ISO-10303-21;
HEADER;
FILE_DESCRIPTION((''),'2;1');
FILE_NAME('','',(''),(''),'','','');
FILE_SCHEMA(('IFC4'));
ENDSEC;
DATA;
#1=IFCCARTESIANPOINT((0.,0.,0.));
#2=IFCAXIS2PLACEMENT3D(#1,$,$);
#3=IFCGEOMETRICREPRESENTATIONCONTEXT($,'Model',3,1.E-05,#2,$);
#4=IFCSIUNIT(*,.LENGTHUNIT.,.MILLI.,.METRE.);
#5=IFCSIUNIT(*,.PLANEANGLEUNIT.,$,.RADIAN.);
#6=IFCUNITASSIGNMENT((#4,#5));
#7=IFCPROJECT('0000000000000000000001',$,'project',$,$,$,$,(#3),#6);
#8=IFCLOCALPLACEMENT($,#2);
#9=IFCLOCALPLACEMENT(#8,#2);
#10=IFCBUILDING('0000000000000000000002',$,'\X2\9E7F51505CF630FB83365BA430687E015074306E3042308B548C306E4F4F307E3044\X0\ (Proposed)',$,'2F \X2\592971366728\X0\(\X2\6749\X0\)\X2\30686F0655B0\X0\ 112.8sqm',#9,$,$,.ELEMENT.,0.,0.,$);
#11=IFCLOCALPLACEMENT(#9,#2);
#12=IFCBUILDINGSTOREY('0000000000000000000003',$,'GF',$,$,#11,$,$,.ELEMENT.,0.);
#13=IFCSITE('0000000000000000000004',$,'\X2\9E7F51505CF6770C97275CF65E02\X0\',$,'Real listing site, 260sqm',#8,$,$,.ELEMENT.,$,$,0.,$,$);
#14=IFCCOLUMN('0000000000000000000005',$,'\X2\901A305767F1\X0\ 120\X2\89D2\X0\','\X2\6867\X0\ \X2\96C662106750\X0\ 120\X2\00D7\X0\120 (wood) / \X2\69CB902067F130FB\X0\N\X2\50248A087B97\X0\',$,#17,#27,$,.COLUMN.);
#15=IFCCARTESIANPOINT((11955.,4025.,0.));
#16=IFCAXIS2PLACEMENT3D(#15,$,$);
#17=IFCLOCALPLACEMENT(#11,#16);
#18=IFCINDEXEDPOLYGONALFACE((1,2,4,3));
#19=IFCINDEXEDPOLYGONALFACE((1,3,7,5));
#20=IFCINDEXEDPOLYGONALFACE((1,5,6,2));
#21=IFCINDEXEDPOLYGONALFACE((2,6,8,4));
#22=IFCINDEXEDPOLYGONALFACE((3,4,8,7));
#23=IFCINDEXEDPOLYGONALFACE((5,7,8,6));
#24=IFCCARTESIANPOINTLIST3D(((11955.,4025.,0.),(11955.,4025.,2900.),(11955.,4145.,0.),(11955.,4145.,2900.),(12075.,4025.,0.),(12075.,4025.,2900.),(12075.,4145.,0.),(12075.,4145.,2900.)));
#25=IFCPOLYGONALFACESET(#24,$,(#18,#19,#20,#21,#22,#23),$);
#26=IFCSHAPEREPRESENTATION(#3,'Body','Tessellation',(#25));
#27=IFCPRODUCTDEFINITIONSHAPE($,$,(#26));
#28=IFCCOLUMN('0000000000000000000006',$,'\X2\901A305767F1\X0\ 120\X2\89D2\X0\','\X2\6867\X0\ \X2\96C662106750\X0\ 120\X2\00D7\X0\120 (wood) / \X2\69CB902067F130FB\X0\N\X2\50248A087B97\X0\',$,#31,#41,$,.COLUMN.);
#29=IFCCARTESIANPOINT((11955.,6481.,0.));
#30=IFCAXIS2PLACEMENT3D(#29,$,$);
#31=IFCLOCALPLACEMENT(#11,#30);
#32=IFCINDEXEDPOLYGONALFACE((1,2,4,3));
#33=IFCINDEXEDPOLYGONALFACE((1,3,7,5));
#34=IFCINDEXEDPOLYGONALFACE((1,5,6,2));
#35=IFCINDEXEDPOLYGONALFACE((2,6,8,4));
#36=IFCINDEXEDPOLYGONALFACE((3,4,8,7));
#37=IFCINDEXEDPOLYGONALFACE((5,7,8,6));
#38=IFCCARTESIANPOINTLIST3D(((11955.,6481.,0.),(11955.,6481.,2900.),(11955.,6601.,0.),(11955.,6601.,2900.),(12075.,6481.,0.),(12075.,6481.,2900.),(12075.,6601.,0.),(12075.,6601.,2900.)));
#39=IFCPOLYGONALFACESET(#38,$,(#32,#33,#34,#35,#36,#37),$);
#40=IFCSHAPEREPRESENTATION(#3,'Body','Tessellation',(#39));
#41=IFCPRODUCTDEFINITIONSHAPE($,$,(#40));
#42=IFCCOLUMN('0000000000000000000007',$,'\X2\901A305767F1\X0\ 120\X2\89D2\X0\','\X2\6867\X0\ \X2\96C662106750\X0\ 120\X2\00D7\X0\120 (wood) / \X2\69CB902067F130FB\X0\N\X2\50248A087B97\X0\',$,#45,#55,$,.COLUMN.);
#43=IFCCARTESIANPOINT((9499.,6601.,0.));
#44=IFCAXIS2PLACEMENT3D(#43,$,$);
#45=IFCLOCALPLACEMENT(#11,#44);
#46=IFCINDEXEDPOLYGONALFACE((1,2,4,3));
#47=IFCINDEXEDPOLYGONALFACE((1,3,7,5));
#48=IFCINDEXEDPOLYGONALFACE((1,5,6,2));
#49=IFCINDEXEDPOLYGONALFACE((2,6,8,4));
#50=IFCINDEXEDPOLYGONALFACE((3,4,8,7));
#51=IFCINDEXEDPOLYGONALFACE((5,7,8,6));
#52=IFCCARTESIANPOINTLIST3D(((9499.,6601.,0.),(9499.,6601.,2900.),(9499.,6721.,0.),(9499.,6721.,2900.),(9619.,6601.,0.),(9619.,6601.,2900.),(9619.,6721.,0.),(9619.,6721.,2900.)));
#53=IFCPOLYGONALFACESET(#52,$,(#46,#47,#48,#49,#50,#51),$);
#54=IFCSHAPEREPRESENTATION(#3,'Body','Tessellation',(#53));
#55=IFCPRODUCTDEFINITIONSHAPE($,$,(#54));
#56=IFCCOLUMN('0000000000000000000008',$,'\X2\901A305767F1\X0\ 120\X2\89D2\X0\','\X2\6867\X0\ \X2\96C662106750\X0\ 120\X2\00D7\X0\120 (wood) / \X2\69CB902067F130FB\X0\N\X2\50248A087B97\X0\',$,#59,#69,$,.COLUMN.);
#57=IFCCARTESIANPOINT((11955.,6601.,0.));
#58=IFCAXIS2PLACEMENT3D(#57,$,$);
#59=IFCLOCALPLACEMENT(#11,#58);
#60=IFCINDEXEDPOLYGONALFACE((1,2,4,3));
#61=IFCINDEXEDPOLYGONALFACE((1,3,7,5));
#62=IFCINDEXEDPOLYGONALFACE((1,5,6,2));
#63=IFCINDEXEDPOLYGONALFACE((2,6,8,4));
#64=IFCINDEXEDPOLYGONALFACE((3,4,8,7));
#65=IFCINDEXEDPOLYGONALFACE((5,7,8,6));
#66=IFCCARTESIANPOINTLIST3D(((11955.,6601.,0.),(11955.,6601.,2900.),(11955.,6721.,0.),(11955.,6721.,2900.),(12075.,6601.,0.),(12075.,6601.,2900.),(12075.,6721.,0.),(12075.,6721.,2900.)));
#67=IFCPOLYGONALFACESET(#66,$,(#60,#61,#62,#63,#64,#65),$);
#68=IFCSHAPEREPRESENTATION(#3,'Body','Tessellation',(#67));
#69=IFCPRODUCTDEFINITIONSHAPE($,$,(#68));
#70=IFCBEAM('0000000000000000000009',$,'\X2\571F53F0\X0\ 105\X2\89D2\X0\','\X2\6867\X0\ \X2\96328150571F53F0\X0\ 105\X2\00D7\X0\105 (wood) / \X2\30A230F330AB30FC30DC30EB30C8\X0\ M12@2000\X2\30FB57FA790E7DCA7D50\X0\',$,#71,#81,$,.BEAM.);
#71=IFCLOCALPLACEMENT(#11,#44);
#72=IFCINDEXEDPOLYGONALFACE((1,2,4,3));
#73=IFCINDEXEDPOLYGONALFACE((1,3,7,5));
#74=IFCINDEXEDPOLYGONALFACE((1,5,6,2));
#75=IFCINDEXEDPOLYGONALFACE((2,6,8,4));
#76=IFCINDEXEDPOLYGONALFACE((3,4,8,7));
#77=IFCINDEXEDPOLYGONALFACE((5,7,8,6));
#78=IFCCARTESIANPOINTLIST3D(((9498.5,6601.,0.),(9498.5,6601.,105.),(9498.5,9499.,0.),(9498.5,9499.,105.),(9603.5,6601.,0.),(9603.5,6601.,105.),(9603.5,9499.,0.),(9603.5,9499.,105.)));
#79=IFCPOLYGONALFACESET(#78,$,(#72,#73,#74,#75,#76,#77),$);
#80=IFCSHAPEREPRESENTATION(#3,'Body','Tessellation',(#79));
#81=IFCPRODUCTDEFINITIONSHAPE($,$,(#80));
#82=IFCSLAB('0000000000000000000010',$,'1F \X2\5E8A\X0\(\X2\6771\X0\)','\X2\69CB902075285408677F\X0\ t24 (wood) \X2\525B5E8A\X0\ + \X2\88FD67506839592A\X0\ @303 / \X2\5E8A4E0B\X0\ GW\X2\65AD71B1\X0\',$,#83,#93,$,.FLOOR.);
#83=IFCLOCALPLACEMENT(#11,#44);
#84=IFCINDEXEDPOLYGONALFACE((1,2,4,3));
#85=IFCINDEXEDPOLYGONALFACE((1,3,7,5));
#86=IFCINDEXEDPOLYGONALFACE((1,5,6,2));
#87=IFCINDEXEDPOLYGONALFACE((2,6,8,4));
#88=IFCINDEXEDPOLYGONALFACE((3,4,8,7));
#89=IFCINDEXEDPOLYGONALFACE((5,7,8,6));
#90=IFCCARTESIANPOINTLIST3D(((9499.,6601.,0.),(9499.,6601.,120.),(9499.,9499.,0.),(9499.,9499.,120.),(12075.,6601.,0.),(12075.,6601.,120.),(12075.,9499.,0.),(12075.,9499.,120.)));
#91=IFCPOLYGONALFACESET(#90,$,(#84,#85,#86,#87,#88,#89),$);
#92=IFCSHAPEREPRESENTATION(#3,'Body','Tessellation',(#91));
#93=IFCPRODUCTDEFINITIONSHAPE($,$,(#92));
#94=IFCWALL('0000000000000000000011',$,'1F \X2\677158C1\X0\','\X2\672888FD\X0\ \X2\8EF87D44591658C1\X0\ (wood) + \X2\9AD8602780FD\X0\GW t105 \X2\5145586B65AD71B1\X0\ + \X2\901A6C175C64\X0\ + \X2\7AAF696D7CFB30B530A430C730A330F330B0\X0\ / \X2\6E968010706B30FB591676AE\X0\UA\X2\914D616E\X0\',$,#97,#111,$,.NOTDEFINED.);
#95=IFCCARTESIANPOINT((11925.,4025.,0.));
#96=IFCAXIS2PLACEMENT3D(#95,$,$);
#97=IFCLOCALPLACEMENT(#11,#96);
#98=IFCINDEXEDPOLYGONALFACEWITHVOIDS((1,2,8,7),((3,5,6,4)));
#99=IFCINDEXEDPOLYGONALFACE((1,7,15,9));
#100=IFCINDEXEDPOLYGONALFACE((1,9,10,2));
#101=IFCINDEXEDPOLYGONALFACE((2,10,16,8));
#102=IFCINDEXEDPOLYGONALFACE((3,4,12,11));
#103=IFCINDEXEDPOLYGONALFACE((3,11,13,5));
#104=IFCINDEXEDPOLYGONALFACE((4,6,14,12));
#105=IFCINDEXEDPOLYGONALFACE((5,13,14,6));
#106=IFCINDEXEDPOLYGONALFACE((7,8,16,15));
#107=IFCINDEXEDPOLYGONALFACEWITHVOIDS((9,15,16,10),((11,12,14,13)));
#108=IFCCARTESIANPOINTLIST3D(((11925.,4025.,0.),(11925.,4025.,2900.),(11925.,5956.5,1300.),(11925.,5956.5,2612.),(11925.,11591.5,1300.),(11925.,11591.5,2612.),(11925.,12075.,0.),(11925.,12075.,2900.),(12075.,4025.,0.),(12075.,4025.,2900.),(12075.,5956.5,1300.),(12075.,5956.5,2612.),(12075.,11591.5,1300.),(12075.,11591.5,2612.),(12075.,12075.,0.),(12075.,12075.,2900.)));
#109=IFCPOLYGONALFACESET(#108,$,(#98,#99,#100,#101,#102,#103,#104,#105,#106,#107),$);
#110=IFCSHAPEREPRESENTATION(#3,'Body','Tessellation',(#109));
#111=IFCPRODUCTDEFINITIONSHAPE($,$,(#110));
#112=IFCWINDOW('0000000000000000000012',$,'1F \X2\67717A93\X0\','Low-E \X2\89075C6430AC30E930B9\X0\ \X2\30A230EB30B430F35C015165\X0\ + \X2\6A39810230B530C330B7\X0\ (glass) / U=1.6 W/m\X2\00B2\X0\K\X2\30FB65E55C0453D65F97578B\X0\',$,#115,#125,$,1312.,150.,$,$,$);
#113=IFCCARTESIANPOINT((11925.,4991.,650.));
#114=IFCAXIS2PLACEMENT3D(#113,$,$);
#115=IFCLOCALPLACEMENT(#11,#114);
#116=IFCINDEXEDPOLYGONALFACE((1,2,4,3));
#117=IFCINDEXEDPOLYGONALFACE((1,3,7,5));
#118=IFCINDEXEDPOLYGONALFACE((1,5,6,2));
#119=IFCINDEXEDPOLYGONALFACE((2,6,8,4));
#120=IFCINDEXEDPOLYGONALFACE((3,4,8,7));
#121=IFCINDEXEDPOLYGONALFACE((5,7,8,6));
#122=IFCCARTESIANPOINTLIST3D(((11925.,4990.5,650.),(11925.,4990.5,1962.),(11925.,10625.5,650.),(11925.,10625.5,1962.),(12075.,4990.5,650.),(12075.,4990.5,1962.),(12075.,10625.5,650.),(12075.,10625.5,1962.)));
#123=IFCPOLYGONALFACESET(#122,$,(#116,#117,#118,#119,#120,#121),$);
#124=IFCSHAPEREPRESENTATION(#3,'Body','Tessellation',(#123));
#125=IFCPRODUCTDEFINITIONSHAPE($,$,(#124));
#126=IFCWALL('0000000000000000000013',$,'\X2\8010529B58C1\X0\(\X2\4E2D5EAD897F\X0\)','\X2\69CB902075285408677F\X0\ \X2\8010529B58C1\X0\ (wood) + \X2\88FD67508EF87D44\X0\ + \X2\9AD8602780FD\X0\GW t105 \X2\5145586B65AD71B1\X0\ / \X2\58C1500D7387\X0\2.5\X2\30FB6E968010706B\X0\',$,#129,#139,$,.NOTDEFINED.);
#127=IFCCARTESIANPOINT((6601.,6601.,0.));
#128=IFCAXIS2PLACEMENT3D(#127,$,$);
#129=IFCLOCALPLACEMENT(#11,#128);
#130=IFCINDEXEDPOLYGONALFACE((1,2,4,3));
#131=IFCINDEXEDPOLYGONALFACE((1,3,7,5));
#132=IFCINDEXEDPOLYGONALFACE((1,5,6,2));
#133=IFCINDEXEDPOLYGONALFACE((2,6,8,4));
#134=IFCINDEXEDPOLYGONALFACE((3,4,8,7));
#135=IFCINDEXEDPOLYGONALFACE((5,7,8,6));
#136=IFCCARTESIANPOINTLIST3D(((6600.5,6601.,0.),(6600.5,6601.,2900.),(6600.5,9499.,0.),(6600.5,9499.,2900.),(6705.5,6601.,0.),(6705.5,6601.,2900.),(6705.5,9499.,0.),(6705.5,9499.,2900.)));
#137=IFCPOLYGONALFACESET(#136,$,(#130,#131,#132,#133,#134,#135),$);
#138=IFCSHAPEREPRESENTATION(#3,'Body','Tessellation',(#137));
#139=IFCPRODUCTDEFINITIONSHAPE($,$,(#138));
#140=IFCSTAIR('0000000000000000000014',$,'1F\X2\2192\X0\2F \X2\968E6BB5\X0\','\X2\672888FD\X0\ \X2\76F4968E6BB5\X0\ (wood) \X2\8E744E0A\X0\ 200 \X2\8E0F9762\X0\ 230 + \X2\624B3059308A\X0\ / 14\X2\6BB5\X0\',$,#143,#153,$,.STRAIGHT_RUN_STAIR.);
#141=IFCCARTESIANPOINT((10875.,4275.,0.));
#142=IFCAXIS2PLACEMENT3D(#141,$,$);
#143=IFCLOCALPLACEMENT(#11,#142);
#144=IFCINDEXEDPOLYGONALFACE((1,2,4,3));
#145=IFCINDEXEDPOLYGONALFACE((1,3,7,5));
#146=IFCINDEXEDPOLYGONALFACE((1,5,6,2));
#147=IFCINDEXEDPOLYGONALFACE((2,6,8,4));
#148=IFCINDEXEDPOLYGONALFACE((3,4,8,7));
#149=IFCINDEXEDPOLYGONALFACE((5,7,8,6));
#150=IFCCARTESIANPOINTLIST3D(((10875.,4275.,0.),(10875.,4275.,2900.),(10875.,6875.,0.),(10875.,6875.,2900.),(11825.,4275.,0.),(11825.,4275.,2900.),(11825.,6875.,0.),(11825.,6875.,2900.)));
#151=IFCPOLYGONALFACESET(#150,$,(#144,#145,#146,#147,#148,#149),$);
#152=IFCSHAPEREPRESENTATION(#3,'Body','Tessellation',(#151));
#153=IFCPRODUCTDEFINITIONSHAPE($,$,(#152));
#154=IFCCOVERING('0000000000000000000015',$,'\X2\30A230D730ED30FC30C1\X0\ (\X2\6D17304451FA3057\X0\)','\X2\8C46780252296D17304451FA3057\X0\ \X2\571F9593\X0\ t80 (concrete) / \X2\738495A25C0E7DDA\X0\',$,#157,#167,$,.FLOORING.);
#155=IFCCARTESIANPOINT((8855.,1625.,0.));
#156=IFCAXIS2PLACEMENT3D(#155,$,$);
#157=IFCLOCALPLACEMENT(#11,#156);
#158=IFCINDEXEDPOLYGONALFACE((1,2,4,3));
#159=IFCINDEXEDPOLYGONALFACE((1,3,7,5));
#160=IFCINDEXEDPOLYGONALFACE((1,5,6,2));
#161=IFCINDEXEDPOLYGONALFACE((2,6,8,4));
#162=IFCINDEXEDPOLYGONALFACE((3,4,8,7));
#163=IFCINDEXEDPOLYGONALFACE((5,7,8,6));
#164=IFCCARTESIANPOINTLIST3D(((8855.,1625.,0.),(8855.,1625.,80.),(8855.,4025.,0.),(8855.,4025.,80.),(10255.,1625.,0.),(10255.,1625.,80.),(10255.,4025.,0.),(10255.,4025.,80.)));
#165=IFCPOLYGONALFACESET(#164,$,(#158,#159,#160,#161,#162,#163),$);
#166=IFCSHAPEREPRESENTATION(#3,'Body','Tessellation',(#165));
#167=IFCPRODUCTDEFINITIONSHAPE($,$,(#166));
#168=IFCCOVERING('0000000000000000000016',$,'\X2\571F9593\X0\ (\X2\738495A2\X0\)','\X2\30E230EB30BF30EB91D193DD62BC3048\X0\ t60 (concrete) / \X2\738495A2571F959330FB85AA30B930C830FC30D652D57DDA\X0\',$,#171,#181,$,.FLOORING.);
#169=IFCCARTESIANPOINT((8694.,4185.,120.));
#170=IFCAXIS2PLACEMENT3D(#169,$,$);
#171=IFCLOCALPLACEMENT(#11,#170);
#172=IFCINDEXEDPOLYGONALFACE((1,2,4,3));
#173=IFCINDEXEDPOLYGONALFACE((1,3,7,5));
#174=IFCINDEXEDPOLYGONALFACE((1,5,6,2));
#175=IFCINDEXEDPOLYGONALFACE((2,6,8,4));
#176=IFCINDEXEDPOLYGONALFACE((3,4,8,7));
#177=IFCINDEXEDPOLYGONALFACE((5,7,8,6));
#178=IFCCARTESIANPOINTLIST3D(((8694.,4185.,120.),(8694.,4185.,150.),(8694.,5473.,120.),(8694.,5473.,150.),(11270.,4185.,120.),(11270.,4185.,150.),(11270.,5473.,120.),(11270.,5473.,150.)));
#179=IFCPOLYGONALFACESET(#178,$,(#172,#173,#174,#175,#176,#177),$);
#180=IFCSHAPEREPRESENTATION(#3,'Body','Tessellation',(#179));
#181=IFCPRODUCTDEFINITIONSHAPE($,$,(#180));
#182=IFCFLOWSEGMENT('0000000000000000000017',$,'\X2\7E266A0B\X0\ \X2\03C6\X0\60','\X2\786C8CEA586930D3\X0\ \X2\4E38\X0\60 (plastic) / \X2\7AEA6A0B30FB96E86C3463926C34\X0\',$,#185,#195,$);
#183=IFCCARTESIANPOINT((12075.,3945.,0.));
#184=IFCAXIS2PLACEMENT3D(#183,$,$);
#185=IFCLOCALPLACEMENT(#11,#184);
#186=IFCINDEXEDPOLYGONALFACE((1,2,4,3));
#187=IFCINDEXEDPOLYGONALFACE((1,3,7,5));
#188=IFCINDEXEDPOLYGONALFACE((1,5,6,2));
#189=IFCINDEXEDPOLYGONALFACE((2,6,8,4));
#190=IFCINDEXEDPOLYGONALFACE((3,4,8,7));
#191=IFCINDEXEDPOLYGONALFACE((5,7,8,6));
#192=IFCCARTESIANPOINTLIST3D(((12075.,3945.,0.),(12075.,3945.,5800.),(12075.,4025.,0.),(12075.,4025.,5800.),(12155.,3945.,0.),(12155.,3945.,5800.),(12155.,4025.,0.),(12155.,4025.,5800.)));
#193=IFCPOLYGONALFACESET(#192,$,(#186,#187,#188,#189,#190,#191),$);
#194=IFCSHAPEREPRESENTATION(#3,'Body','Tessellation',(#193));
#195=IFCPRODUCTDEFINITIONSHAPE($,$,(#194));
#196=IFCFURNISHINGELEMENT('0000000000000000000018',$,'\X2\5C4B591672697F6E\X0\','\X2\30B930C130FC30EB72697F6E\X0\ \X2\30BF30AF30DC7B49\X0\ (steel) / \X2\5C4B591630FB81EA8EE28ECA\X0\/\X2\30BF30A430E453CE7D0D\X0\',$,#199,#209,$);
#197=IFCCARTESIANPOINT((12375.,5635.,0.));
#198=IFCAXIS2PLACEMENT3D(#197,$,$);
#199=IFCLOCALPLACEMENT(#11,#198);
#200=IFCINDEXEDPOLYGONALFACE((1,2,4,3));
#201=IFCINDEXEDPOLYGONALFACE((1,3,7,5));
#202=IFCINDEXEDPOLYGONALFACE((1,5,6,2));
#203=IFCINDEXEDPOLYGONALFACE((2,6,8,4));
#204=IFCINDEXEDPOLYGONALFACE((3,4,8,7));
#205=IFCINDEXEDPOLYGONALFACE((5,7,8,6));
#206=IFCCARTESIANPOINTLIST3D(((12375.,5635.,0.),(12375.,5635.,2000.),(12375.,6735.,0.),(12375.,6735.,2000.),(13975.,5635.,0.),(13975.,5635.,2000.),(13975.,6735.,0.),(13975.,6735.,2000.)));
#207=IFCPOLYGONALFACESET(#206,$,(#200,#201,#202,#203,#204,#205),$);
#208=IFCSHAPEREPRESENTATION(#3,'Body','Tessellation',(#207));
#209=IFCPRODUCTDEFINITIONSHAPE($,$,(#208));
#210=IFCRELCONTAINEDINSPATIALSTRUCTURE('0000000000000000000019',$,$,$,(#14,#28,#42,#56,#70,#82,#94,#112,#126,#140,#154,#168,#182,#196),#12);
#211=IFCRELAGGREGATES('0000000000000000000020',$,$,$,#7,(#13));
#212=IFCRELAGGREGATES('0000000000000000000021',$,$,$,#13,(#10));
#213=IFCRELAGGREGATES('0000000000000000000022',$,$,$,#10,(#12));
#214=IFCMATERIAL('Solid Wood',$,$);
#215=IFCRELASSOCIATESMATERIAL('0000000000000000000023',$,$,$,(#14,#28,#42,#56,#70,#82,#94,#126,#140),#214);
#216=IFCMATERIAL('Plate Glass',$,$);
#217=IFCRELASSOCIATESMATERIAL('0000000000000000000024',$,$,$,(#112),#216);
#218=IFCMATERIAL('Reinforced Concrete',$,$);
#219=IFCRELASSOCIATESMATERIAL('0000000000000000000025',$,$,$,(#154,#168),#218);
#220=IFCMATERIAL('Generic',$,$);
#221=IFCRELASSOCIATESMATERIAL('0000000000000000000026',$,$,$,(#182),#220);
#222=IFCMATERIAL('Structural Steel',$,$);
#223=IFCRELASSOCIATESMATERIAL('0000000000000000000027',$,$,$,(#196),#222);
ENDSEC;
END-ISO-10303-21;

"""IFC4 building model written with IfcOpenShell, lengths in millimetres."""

from ifc_helpers import new_model, si_unit, frame, frame_2d, origin, place, context, project, spatial, rectangle, extrude, material, element, fill, save


model = new_model("IFC4")

# Units and contexts
model_context = context("Model", 3, precision=1e-05, world=origin())
ifc_project = project(units=[si_unit("LENGTHUNIT", "METRE", prefix="MILLI"), si_unit("PLANEANGLEUNIT", "RADIAN")], contexts=[model_context])

# Site, building, storey
site_placement = place(None, origin())
site = spatial("IfcSite", under=ifc_project, at=site_placement, Name="鹿児島県霧島市", ObjectType="Real listing site, 260sqm", CompositionType="ELEMENT", RefElevation=0.0)
building_placement = place(site_placement, origin())
building = spatial("IfcBuilding", under=site, at=building_placement, Name="鹿児島・茶室と縁側のある和の住まい (Proposed)", ObjectType="2F 天然木(杉)と漆喰 112.8sqm", CompositionType="ELEMENT", ElevationOfRefHeight=0.0, ElevationOfTerrain=0.0)
storey_placement = place(building_placement, origin())
storey = spatial("IfcBuildingStorey", under=building, at=storey_placement, Name="GF", CompositionType="ELEMENT", Elevation=0.0)

# Columns
ifc_material_1 = material(Name="Solid Wood")
column_1_placement = place(storey_placement, frame((11955.0, 4025.0, 0.0)))
element("IfcColumn", 1, at=column_1_placement, inside=storey, material=ifc_material_1, Name="通し柱 120角", Description="桧 集成材 120×120 (wood) / 構造柱・N値計算", PredefinedType="COLUMN", context=model_context, shape_type="SweptSolid", body=[
    extrude(rectangle(XDim=120.0, YDim=120.0, at=frame_2d((60.0, 60.0))), frame((11955.0, 4025.0, 0.0)), (0.0, 0.0, 1.0), 2900.0),
])
column_2_placement = place(storey_placement, frame((11955.0, 6481.0, 0.0)))
element("IfcColumn", 2, at=column_2_placement, inside=storey, material=ifc_material_1, Name="通し柱 120角", Description="桧 集成材 120×120 (wood) / 構造柱・N値計算", PredefinedType="COLUMN", context=model_context, shape_type="SweptSolid", body=[
    extrude(rectangle(XDim=120.0, YDim=120.0, at=frame_2d((60.0, 60.0))), frame((11955.0, 6481.0, 0.0)), (0.0, 0.0, 1.0), 2900.0),
])
column_3_placement = place(storey_placement, frame((9499.0, 6601.0, 0.0)))
element("IfcColumn", 3, at=column_3_placement, inside=storey, material=ifc_material_1, Name="通し柱 120角", Description="桧 集成材 120×120 (wood) / 構造柱・N値計算", PredefinedType="COLUMN", context=model_context, shape_type="SweptSolid", body=[
    extrude(rectangle(XDim=120.0, YDim=120.0, at=frame_2d((60.0, 60.0))), frame((9499.0, 6601.0, 0.0)), (0.0, 0.0, 1.0), 2900.0),
])
column_4_placement = place(storey_placement, frame((11955.0, 6601.0, 0.0)))
element("IfcColumn", 4, at=column_4_placement, inside=storey, material=ifc_material_1, Name="通し柱 120角", Description="桧 集成材 120×120 (wood) / 構造柱・N値計算", PredefinedType="COLUMN", context=model_context, shape_type="SweptSolid", body=[
    extrude(rectangle(XDim=120.0, YDim=120.0, at=frame_2d((60.0, 60.0))), frame((11955.0, 6601.0, 0.0)), (0.0, 0.0, 1.0), 2900.0),
])

# Beam
beam_1_placement = place(storey_placement, frame((9499.0, 6601.0, 0.0)))
element("IfcBeam", 5, at=beam_1_placement, inside=storey, material=ifc_material_1, Name="土台 105角", Description="桧 防腐土台 105×105 (wood) / アンカーボルト M12@2000・基礎緊結", PredefinedType="BEAM", context=model_context, shape_type="SweptSolid", body=[
    extrude(rectangle(XDim=105.0, YDim=2898.0, at=frame_2d((52.0, 1449.0))), frame((9499.0, 6601.0, 0.0)), (0.0, 0.0, 1.0), 105.0),
])

# Slab
slab_placement = place(storey_placement, frame((9499.0, 6601.0, 0.0)))
element("IfcSlab", 6, at=slab_placement, inside=storey, material=ifc_material_1, Name="1F 床(東)", Description="構造用合板 t24 (wood) 剛床 + 製材根太 @303 / 床下 GW断熱", PredefinedType="FLOOR", context=model_context, shape_type="SweptSolid", body=[
    extrude(rectangle(XDim=2576.0, YDim=2898.0, at=frame_2d((1288.0, 1449.0))), frame((9499.0, 6601.0, 0.0)), (0.0, 0.0, 1.0), 120.0),
])

# Wall, opening, window
wall_1_placement = place(storey_placement, frame((11925.0, 4025.0, 0.0)))
wall_1 = element("IfcWall", 7, at=wall_1_placement, inside=storey, material=ifc_material_1, Name="1F 東壁", Description="木製 軸組外壁 (wood) + 高性能GW t105 充填断熱 + 通気層 + 窯業系サイディング / 準耐火・外皮UA配慮", PredefinedType="NOTDEFINED", context=model_context, shape_type="SweptSolid", body=[
    extrude(rectangle(XDim=150.0, YDim=8050.0, at=frame_2d((75.0, 4025.0))), frame((11925.0, 4025.0, 0.0)), (0.0, 0.0, 1.0), 2900.0),
])
opening_placement = place(storey_placement, frame((11925.0, 4991.0, 650.0)))
opening = element("IfcOpeningElement", 8, at=opening_placement, cuts=wall_1, PredefinedType="NOTDEFINED", context=model_context, shape_type="SweptSolid", body=[
    extrude(rectangle(XDim=150.0, YDim=5635.0, at=frame_2d((75.0, 2817.0))), frame((11925.0, 4991.0, 650.0)), (0.0, 0.0, 1.0), 1312.0),
])
ifc_material_2 = material(Name="Plate Glass")
window_placement = place(storey_placement, frame((11925.0, 4991.0, 650.0)))
window = element("IfcWindow", 9, at=window_placement, inside=storey, material=ifc_material_2, Name="1F 東窓", Description="Low-E 複層ガラス アルゴン封入 + 樹脂サッシ (glass) / U=1.6 W/m²K・日射取得型", OverallHeight=1312.0, OverallWidth=150.0, context=model_context, shape_type="SweptSolid", body=[
    extrude(rectangle(XDim=150.0, YDim=5635.0, at=frame_2d((75.0, 2817.0))), frame((11925.0, 4991.0, 650.0)), (0.0, 0.0, 1.0), 1312.0),
])
fill(opening, window)

# Wall
wall_2_placement = place(storey_placement, frame((6601.0, 6601.0, 0.0)))
element("IfcWall", 10, at=wall_2_placement, inside=storey, material=ifc_material_1, Name="耐力壁(中庭西)", Description="構造用合板 耐力壁 (wood) + 製材軸組 + 高性能GW t105 充填断熱 / 壁倍率2.5・準耐火", PredefinedType="NOTDEFINED", context=model_context, shape_type="SweptSolid", body=[
    extrude(rectangle(XDim=105.0, YDim=2898.0, at=frame_2d((52.0, 1449.0))), frame((6601.0, 6601.0, 0.0)), (0.0, 0.0, 1.0), 2900.0),
])

# Stair
stair_placement = place(storey_placement, frame((10875.0, 4275.0, 0.0)))
element("IfcStair", 11, at=stair_placement, inside=storey, material=ifc_material_1, Name="1F→2F 階段", Description="木製 直階段 (wood) 蹴上 200 踏面 230 + 手すり / 14段", PredefinedType="STRAIGHT_RUN_STAIR", context=model_context, shape_type="SweptSolid", body=[
    extrude(rectangle(XDim=950.0, YDim=2600.0, at=frame_2d((475.0, 1300.0))), frame((10875.0, 4275.0, 0.0)), (0.0, 0.0, 1.0), 2900.0),
])

# Coverings
ifc_material_3 = material(Name="Reinforced Concrete")
covering_1_placement = place(storey_placement, frame((8855.0, 1625.0, 0.0)))
element("IfcCovering", 12, at=covering_1_placement, inside=storey, material=ifc_material_3, Name="アプローチ (洗い出し)", Description="豆砂利洗い出し 土間 t80 (concrete) / 玄関導線", PredefinedType="FLOORING", context=model_context, shape_type="SweptSolid", body=[
    extrude(rectangle(XDim=1400.0, YDim=2400.0, at=frame_2d((700.0, 1200.0))), frame((8855.0, 1625.0, 0.0)), (0.0, 0.0, 1.0), 80.0),
])
covering_2_placement = place(storey_placement, frame((8694.0, 4185.0, 120.0)))
element("IfcCovering", 13, at=covering_2_placement, inside=storey, material=ifc_material_3, Name="土間 (玄関)", Description="モルタル金鏝押え t60 (concrete) / 玄関土間・薪ストーブ動線", PredefinedType="FLOORING", context=model_context, shape_type="SweptSolid", body=[
    extrude(rectangle(XDim=2576.0, YDim=1288.0, at=frame_2d((1288.0, 644.0))), frame((8694.0, 4185.0, 120.0)), (0.0, 0.0, 1.0), 30.0),
])

# Flow segment
ifc_material_4 = material(Name="Generic")
flow_segment_placement = place(storey_placement, frame((12075.0, 3945.0, 0.0)))
element("IfcFlowSegment", 14, at=flow_segment_placement, inside=storey, material=ifc_material_4, Name="縦樋 φ60", Description="硬質塩ビ 丸60 (plastic) / 竪樋・雨水排水", context=model_context, shape_type="SweptSolid", body=[
    extrude(rectangle(XDim=80.0, YDim=80.0, at=frame_2d((40.0, 40.0))), frame((12075.0, 3945.0, 0.0)), (0.0, 0.0, 1.0), 5800.0),
])

# Furnishing element
ifc_material_5 = material(Name="Structural Steel")
furnishing_placement = place(storey_placement, frame((12375.0, 5635.0, 0.0)))
element("IfcFurnishingElement", 15, at=furnishing_placement, inside=storey, material=ifc_material_5, Name="屋外物置", Description="スチール物置 タクボ等 (steel) / 屋外・自転車/タイヤ収納", context=model_context, shape_type="SweptSolid", body=[
    extrude(rectangle(XDim=1600.0, YDim=1100.0, at=frame_2d((800.0, 550.0))), frame((12375.0, 5635.0, 0.0)), (0.0, 0.0, 1.0), 2000.0),
])

save(model, "model.ifc")
